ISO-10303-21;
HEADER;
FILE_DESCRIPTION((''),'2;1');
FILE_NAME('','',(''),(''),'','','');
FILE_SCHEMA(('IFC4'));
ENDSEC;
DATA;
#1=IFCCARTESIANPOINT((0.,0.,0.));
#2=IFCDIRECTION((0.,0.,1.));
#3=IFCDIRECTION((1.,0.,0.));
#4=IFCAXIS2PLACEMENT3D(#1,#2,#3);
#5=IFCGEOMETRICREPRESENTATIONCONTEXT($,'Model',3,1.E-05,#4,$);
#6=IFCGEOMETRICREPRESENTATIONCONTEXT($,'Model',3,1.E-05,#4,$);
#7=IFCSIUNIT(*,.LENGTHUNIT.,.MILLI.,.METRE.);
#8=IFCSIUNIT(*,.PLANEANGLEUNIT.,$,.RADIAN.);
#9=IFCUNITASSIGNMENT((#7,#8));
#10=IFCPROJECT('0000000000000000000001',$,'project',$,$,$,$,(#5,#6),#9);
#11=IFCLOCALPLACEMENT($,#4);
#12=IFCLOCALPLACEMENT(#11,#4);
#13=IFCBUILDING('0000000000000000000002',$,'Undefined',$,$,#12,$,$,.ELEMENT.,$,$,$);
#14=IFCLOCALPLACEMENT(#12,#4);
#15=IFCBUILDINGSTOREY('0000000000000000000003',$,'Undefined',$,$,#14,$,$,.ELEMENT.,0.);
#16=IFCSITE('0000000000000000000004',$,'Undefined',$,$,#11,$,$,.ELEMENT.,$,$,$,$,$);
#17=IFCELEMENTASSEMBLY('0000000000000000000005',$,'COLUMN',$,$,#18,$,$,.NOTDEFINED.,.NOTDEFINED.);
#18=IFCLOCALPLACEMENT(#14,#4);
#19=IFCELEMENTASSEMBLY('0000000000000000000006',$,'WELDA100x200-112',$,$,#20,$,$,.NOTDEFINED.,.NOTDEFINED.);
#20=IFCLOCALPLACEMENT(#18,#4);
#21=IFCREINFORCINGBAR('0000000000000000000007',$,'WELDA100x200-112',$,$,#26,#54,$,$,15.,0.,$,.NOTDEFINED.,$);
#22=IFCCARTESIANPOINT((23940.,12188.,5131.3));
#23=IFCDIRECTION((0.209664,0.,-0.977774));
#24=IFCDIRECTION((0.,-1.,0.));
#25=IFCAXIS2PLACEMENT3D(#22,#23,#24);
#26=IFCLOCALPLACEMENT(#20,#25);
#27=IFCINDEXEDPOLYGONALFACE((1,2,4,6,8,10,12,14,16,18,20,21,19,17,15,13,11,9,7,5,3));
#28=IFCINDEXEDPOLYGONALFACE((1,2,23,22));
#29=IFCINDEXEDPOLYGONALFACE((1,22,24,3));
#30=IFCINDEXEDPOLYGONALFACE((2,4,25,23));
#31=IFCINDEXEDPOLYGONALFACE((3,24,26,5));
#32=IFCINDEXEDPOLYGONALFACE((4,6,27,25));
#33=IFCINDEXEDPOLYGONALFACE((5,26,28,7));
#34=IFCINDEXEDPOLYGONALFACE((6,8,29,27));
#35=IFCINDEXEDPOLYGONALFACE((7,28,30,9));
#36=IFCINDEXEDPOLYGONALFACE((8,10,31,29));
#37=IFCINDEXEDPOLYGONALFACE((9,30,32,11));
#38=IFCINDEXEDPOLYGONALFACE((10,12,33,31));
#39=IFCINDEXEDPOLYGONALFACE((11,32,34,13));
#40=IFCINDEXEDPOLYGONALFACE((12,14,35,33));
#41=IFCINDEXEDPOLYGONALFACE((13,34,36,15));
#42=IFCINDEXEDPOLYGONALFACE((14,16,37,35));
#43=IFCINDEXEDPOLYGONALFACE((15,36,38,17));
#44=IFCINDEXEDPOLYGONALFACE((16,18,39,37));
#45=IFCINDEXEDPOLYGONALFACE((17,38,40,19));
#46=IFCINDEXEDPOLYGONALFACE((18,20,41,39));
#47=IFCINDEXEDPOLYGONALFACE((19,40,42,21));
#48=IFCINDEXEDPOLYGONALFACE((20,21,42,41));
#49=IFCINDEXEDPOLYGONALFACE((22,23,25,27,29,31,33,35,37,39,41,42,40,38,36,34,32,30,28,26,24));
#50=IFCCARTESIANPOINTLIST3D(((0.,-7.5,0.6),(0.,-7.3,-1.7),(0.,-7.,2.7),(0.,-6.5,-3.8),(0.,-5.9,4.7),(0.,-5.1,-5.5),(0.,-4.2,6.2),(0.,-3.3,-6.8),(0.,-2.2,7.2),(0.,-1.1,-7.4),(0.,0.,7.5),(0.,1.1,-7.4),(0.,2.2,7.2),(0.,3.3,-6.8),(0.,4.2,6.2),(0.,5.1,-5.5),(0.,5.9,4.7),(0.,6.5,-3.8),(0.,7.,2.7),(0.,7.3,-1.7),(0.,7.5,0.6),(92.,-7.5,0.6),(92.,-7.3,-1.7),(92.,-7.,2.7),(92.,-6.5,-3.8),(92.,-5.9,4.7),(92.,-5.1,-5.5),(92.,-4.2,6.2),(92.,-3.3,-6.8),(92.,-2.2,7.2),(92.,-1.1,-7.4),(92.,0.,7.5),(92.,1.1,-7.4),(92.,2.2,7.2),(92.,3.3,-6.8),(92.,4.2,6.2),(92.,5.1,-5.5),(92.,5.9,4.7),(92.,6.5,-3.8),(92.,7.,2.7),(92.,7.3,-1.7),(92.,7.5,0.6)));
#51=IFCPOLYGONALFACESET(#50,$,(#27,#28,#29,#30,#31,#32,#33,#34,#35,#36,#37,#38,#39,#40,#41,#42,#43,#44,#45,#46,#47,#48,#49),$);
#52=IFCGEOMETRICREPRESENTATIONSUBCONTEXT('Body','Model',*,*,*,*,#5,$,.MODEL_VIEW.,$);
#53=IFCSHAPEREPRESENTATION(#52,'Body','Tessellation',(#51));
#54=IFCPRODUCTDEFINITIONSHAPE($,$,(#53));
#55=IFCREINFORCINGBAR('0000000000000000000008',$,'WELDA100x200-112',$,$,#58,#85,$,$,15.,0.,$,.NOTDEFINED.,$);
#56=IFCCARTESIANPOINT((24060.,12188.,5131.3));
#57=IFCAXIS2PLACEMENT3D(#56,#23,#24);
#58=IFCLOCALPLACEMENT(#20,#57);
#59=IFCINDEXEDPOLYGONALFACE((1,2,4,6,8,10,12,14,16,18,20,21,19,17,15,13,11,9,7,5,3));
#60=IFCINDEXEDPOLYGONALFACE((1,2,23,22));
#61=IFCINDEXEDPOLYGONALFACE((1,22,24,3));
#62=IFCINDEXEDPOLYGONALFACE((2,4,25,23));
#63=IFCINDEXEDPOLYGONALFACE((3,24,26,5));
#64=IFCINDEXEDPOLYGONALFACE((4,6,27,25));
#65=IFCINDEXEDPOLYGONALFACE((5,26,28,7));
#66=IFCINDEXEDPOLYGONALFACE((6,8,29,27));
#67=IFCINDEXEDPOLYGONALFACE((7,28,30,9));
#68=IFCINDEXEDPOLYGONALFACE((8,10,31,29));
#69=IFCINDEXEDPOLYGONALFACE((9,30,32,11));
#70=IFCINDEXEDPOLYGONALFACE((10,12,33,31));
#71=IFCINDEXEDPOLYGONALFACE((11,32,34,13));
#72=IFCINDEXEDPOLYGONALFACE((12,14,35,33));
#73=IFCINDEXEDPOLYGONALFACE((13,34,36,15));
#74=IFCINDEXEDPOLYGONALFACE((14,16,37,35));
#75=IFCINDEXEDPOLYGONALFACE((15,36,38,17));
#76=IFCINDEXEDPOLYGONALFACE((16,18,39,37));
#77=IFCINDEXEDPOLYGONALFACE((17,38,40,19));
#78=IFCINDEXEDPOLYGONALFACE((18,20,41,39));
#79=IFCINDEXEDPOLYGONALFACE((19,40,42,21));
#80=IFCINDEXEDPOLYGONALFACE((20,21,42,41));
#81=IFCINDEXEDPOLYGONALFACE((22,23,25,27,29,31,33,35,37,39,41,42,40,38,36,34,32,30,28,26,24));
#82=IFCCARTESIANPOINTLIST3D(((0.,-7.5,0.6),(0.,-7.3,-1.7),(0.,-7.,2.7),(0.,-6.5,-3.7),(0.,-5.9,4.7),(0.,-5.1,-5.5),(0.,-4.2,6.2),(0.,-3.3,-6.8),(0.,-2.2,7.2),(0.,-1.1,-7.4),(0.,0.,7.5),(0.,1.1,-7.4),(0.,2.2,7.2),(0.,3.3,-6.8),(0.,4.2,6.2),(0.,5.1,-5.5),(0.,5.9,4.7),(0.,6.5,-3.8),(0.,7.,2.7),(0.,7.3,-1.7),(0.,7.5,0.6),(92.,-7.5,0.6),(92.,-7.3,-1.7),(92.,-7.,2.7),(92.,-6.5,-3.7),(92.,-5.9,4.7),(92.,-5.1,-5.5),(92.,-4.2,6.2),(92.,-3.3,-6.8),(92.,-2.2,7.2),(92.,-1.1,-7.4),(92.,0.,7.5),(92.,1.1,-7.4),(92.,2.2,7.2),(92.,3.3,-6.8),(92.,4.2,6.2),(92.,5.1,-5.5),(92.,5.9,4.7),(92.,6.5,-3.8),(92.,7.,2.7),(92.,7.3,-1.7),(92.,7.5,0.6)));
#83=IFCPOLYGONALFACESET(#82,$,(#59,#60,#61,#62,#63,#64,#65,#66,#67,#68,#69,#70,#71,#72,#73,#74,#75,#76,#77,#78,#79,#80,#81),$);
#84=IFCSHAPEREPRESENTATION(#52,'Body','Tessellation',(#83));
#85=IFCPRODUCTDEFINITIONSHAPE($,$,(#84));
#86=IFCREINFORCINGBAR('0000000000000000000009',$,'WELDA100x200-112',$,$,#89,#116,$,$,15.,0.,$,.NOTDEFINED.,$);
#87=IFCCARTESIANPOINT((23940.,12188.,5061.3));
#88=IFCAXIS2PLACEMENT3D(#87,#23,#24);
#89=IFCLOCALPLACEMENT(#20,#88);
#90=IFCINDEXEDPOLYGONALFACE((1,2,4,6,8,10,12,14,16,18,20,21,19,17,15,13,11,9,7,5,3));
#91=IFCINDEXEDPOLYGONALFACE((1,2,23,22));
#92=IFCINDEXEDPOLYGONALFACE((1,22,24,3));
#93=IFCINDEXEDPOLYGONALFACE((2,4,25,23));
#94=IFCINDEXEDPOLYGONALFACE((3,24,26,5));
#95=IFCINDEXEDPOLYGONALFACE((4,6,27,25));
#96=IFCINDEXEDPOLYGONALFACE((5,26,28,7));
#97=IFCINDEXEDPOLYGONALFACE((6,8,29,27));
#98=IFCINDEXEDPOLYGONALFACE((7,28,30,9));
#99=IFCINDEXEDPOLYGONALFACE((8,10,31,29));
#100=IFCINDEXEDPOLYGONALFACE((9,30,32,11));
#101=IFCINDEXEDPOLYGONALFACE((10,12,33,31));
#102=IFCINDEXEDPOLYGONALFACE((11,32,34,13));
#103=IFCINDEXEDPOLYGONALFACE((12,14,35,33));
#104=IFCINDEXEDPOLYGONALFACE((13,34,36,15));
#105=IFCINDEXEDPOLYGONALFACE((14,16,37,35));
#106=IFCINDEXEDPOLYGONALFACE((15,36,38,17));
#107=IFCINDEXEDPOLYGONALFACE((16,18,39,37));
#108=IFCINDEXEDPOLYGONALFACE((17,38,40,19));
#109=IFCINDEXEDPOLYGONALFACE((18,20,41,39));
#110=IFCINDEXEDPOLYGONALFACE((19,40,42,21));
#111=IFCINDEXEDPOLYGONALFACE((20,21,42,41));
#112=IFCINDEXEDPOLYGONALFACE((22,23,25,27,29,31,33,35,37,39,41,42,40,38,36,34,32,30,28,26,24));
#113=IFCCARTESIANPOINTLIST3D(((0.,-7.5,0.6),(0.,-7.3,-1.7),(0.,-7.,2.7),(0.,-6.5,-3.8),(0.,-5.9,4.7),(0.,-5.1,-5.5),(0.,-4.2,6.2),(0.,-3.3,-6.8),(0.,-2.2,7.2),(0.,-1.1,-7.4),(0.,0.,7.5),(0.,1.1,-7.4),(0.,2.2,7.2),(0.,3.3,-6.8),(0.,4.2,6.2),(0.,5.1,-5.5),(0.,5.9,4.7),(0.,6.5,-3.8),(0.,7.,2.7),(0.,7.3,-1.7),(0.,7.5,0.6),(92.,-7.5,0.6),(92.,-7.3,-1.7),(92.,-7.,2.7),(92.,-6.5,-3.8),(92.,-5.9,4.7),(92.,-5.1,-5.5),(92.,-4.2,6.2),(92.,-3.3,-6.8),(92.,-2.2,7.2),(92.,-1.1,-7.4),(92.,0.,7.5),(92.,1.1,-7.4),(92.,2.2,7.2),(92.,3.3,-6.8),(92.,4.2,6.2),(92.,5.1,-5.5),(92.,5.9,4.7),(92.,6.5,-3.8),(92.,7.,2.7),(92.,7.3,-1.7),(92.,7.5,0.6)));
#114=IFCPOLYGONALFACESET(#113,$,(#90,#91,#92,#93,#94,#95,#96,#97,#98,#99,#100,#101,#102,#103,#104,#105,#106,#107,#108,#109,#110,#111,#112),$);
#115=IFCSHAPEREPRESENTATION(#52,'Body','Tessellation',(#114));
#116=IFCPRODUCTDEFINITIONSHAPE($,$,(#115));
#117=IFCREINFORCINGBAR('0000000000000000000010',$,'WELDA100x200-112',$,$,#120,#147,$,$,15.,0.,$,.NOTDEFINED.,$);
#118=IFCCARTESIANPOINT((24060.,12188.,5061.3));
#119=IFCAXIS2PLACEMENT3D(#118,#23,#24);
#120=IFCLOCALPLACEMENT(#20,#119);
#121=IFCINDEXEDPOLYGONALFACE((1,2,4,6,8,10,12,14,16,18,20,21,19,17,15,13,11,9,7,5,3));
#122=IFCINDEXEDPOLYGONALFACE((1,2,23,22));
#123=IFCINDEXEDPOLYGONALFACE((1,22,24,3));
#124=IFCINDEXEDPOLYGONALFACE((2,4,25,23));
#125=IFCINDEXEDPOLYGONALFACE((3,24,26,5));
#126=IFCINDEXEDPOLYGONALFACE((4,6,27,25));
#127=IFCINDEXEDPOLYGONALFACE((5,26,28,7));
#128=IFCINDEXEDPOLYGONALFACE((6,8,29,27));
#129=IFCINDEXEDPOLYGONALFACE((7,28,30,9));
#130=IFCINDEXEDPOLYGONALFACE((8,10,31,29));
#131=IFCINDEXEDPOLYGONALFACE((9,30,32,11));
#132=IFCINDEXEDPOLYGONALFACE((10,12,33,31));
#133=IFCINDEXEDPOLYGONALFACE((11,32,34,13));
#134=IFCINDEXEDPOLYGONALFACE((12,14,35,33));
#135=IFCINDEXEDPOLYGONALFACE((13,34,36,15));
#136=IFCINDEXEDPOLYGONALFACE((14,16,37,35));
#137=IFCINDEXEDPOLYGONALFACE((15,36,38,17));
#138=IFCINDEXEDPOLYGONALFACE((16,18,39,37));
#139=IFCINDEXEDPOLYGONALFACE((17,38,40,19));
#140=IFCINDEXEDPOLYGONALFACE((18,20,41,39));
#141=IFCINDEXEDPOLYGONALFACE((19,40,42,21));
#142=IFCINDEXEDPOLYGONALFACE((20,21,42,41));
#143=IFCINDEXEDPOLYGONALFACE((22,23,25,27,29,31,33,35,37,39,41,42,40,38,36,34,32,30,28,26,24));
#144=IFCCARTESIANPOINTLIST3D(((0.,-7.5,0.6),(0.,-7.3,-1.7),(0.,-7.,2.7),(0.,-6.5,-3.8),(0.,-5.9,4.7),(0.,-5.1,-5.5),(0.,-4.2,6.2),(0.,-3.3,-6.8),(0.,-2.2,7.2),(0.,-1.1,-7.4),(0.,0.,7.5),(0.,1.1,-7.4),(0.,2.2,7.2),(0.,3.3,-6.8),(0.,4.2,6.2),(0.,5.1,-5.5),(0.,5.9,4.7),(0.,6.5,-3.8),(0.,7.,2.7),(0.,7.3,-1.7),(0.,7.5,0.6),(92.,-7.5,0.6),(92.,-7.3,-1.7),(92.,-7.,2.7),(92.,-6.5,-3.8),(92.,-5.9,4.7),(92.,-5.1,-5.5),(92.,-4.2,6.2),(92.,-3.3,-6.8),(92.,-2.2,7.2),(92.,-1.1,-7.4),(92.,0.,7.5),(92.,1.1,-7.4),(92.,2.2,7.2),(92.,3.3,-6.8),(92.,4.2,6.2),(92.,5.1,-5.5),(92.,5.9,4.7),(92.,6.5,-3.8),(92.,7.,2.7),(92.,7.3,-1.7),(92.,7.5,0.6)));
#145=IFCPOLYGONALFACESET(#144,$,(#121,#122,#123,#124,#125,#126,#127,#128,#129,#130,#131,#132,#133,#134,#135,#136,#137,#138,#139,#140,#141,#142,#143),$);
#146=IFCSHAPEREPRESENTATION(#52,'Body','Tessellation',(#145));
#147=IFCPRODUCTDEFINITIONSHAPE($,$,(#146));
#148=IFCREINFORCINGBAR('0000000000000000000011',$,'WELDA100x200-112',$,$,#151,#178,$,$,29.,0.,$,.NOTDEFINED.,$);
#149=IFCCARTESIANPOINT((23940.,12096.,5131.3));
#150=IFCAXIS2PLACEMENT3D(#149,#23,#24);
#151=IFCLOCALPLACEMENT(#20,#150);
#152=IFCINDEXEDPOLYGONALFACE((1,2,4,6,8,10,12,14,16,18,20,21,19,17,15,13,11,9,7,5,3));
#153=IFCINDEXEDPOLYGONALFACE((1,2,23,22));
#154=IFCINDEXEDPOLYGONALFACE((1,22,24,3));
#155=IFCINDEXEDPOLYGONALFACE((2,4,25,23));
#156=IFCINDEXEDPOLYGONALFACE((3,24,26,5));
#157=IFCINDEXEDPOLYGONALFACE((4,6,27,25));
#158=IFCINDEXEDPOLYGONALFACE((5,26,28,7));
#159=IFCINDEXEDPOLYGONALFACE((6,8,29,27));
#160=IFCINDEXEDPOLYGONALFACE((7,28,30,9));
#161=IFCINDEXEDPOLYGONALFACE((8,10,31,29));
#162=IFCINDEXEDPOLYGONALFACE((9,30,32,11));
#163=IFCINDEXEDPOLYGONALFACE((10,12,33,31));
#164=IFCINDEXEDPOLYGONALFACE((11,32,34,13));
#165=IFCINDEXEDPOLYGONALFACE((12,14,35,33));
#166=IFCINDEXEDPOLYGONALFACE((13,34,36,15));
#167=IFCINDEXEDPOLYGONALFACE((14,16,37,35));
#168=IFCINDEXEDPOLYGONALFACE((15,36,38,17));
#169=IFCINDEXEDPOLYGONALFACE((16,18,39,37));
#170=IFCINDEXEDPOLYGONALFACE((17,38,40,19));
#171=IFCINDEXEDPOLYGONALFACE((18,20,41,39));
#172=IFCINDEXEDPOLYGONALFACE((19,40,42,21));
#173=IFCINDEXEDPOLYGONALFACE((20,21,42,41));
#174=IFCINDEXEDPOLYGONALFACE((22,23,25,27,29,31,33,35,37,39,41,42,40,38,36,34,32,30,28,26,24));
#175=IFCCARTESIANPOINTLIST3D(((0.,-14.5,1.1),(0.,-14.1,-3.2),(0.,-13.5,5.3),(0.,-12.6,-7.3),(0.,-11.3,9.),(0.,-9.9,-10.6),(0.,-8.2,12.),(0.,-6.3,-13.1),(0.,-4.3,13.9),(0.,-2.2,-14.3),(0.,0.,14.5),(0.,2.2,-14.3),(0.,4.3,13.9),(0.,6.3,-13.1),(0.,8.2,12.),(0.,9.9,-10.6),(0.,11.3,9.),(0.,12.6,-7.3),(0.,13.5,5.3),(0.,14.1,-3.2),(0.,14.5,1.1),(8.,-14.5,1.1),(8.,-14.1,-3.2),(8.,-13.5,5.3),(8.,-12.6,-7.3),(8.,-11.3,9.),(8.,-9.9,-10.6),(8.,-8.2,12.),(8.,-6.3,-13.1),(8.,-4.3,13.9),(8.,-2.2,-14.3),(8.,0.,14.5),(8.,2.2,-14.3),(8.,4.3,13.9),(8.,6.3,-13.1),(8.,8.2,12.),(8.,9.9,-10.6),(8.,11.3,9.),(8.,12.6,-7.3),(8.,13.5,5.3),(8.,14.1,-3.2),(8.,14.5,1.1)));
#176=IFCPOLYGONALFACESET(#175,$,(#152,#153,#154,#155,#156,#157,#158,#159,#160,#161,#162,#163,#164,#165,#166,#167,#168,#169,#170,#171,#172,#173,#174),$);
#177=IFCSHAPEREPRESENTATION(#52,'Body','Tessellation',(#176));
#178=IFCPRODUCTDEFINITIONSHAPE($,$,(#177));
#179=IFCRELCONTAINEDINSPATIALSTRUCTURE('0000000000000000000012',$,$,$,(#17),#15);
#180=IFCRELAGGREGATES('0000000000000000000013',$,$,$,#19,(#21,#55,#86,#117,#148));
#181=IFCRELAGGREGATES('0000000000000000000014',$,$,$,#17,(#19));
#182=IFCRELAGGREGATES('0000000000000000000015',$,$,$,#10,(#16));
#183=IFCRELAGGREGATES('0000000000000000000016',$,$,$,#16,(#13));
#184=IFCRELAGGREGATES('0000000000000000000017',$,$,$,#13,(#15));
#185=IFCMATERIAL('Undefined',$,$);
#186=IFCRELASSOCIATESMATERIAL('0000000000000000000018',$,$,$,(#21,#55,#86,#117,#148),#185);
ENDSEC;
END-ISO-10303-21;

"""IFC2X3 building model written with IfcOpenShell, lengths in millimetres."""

from ifc_helpers import new_model, entity, si_unit, frame, origin_with_axes, place, context, subcontext, project, spatial, source, transform, mapped, material, element, aggregate, save


model = new_model("IFC2X3")

# Units and contexts
model_context_1 = context("Model", 3, precision=1e-05, world=origin_with_axes())
model_context_2 = context("Model", 3, precision=1e-05, world=origin_with_axes())
body_context = subcontext(model_context_1, "Body", "Model", "MODEL_VIEW")
ifc_project = project(units=[si_unit("LENGTHUNIT", "METRE", prefix="MILLI"), si_unit("PLANEANGLEUNIT", "RADIAN")], contexts=[model_context_1, model_context_2])

# Site, building, storey
site_placement = place(None, origin_with_axes())
site = spatial("IfcSite", under=ifc_project, at=site_placement, Name="Undefined", CompositionType="ELEMENT")
building_placement = place(site_placement, origin_with_axes())
building = spatial("IfcBuilding", under=site, at=building_placement, Name="Undefined", CompositionType="ELEMENT")
storey_placement = place(building_placement, origin_with_axes())
storey = spatial("IfcBuildingStorey", under=building, at=storey_placement, Name="Undefined", CompositionType="ELEMENT", Elevation=0.0)

# Element assembly
assembly_1_placement = place(storey_placement, origin_with_axes())
assembly_1 = element("IfcElementAssembly", 1, at=assembly_1_placement, inside=storey, Name="COLUMN", AssemblyPlace="NOTDEFINED", PredefinedType="NOTDEFINED")

# Element assembly
assembly_2_placement = place(assembly_1_placement, origin_with_axes())
assembly_2 = element("IfcElementAssembly", 2, at=assembly_2_placement, Name="WELDA100x200-112", AssemblyPlace="NOTDEFINED", PredefinedType="NOTDEFINED")

# Reinforcing bars
ifc_material_1 = material(Name="Undefined")
shared_shape_1 = source(origin_with_axes(), body_context, "Body", "AdvancedSweptSolid", [
    entity("IfcSweptDiskSolid", entity("IfcTrimmedCurve", entity("IfcLine", entity("IfcCartesianPoint", [0.0, 0.0, 0.0]), entity("IfcVector", entity("IfcDirection", [1.0, 0.0, 0.0]), 1.0)), [entity("IfcParameterValue", 0.0)], [entity("IfcParameterValue", 92.0)], True, "PARAMETER"), 7.5, None, 0.0, 92.0),
])
reinforcing_bar_1_placement = place(assembly_2_placement, frame((23940.0, 12188.0, 5131.3), z_axis=(0.209664, 0.0, -0.977774), x_axis=(0.0, -1.0, 0.0)))
reinforcing_bar_1 = element("IfcReinforcingBar", 3, at=reinforcing_bar_1_placement, material=ifc_material_1, Name="WELDA100x200-112", BarRole="NOTDEFINED", CrossSectionArea=0.0, NominalDiameter=15.0, context=body_context, shape_type="MappedRepresentation", body=[
    mapped(shared_shape_1, transform((0.0, 0.0, 0.0))),
])
shared_shape_2 = source(origin_with_axes(), body_context, "Body", "AdvancedSweptSolid", [
    entity("IfcSweptDiskSolid", entity("IfcTrimmedCurve", entity("IfcLine", entity("IfcCartesianPoint", [0.0, 0.0, 0.0]), entity("IfcVector", entity("IfcDirection", [1.0, 0.0, 0.0]), 1.0)), [entity("IfcParameterValue", 0.0)], [entity("IfcParameterValue", 92.0)], True, "PARAMETER"), 7.5, None, 0.0, 92.0),
])
reinforcing_bar_2_placement = place(assembly_2_placement, frame((24060.0, 12188.0, 5131.3), z_axis=(0.209664, 0.0, -0.977774), x_axis=(0.0, -1.0, 0.0)))
reinforcing_bar_2 = element("IfcReinforcingBar", 4, at=reinforcing_bar_2_placement, material=ifc_material_1, Name="WELDA100x200-112", BarRole="NOTDEFINED", CrossSectionArea=0.0, NominalDiameter=15.0, context=body_context, shape_type="MappedRepresentation", body=[
    mapped(shared_shape_2, transform((0.0, 0.0, 0.0))),
])
shared_shape_3 = source(origin_with_axes(), body_context, "Body", "AdvancedSweptSolid", [
    entity("IfcSweptDiskSolid", entity("IfcTrimmedCurve", entity("IfcLine", entity("IfcCartesianPoint", [0.0, 0.0, 0.0]), entity("IfcVector", entity("IfcDirection", [1.0, 0.0, 0.0]), 1.0)), [entity("IfcParameterValue", 0.0)], [entity("IfcParameterValue", 92.0)], True, "PARAMETER"), 7.5, None, 0.0, 92.0),
])
reinforcing_bar_3_placement = place(assembly_2_placement, frame((23940.0, 12188.0, 5061.3), z_axis=(0.209664, 0.0, -0.977774), x_axis=(0.0, -1.0, 0.0)))
reinforcing_bar_3 = element("IfcReinforcingBar", 5, at=reinforcing_bar_3_placement, material=ifc_material_1, Name="WELDA100x200-112", BarRole="NOTDEFINED", CrossSectionArea=0.0, NominalDiameter=15.0, context=body_context, shape_type="MappedRepresentation", body=[
    mapped(shared_shape_3, transform((0.0, 0.0, 0.0))),
])
shared_shape_4 = source(origin_with_axes(), body_context, "Body", "AdvancedSweptSolid", [
    entity("IfcSweptDiskSolid", entity("IfcTrimmedCurve", entity("IfcLine", entity("IfcCartesianPoint", [0.0, 0.0, 0.0]), entity("IfcVector", entity("IfcDirection", [1.0, 0.0, 0.0]), 1.0)), [entity("IfcParameterValue", 0.0)], [entity("IfcParameterValue", 92.0)], True, "PARAMETER"), 7.5, None, 0.0, 92.0),
])
reinforcing_bar_4_placement = place(assembly_2_placement, frame((24060.0, 12188.0, 5061.3), z_axis=(0.209664, 0.0, -0.977774), x_axis=(0.0, -1.0, 0.0)))
reinforcing_bar_4 = element("IfcReinforcingBar", 6, at=reinforcing_bar_4_placement, material=ifc_material_1, Name="WELDA100x200-112", BarRole="NOTDEFINED", CrossSectionArea=0.0, NominalDiameter=15.0, context=body_context, shape_type="MappedRepresentation", body=[
    mapped(shared_shape_4, transform((0.0, 0.0, 0.0))),
])
shared_shape_5 = source(origin_with_axes(), body_context, "Body", "AdvancedSweptSolid", [
    entity("IfcSweptDiskSolid", entity("IfcTrimmedCurve", entity("IfcLine", entity("IfcCartesianPoint", [0.0, 0.0, 0.0]), entity("IfcVector", entity("IfcDirection", [1.0, 0.0, 0.0]), 1.0)), [entity("IfcParameterValue", 0.0)], [entity("IfcParameterValue", 8.0)], True, "PARAMETER"), 14.5, None, 0.0, 8.0),
])
reinforcing_bar_5_placement = place(assembly_2_placement, frame((23940.0, 12096.0, 5131.3), z_axis=(0.209664, 0.0, -0.977774), x_axis=(0.0, -1.0, 0.0)))
reinforcing_bar_5 = element("IfcReinforcingBar", 7, at=reinforcing_bar_5_placement, material=ifc_material_1, Name="WELDA100x200-112", BarRole="NOTDEFINED", CrossSectionArea=0.0, NominalDiameter=29.0, context=body_context, shape_type="MappedRepresentation", body=[
    mapped(shared_shape_5, transform((0.0, 0.0, 0.0))),
])
aggregate(assembly_2, [reinforcing_bar_1, reinforcing_bar_2, reinforcing_bar_3, reinforcing_bar_4, reinforcing_bar_5])

aggregate(assembly_1, [assembly_2])

save(model, "model.ifc")
